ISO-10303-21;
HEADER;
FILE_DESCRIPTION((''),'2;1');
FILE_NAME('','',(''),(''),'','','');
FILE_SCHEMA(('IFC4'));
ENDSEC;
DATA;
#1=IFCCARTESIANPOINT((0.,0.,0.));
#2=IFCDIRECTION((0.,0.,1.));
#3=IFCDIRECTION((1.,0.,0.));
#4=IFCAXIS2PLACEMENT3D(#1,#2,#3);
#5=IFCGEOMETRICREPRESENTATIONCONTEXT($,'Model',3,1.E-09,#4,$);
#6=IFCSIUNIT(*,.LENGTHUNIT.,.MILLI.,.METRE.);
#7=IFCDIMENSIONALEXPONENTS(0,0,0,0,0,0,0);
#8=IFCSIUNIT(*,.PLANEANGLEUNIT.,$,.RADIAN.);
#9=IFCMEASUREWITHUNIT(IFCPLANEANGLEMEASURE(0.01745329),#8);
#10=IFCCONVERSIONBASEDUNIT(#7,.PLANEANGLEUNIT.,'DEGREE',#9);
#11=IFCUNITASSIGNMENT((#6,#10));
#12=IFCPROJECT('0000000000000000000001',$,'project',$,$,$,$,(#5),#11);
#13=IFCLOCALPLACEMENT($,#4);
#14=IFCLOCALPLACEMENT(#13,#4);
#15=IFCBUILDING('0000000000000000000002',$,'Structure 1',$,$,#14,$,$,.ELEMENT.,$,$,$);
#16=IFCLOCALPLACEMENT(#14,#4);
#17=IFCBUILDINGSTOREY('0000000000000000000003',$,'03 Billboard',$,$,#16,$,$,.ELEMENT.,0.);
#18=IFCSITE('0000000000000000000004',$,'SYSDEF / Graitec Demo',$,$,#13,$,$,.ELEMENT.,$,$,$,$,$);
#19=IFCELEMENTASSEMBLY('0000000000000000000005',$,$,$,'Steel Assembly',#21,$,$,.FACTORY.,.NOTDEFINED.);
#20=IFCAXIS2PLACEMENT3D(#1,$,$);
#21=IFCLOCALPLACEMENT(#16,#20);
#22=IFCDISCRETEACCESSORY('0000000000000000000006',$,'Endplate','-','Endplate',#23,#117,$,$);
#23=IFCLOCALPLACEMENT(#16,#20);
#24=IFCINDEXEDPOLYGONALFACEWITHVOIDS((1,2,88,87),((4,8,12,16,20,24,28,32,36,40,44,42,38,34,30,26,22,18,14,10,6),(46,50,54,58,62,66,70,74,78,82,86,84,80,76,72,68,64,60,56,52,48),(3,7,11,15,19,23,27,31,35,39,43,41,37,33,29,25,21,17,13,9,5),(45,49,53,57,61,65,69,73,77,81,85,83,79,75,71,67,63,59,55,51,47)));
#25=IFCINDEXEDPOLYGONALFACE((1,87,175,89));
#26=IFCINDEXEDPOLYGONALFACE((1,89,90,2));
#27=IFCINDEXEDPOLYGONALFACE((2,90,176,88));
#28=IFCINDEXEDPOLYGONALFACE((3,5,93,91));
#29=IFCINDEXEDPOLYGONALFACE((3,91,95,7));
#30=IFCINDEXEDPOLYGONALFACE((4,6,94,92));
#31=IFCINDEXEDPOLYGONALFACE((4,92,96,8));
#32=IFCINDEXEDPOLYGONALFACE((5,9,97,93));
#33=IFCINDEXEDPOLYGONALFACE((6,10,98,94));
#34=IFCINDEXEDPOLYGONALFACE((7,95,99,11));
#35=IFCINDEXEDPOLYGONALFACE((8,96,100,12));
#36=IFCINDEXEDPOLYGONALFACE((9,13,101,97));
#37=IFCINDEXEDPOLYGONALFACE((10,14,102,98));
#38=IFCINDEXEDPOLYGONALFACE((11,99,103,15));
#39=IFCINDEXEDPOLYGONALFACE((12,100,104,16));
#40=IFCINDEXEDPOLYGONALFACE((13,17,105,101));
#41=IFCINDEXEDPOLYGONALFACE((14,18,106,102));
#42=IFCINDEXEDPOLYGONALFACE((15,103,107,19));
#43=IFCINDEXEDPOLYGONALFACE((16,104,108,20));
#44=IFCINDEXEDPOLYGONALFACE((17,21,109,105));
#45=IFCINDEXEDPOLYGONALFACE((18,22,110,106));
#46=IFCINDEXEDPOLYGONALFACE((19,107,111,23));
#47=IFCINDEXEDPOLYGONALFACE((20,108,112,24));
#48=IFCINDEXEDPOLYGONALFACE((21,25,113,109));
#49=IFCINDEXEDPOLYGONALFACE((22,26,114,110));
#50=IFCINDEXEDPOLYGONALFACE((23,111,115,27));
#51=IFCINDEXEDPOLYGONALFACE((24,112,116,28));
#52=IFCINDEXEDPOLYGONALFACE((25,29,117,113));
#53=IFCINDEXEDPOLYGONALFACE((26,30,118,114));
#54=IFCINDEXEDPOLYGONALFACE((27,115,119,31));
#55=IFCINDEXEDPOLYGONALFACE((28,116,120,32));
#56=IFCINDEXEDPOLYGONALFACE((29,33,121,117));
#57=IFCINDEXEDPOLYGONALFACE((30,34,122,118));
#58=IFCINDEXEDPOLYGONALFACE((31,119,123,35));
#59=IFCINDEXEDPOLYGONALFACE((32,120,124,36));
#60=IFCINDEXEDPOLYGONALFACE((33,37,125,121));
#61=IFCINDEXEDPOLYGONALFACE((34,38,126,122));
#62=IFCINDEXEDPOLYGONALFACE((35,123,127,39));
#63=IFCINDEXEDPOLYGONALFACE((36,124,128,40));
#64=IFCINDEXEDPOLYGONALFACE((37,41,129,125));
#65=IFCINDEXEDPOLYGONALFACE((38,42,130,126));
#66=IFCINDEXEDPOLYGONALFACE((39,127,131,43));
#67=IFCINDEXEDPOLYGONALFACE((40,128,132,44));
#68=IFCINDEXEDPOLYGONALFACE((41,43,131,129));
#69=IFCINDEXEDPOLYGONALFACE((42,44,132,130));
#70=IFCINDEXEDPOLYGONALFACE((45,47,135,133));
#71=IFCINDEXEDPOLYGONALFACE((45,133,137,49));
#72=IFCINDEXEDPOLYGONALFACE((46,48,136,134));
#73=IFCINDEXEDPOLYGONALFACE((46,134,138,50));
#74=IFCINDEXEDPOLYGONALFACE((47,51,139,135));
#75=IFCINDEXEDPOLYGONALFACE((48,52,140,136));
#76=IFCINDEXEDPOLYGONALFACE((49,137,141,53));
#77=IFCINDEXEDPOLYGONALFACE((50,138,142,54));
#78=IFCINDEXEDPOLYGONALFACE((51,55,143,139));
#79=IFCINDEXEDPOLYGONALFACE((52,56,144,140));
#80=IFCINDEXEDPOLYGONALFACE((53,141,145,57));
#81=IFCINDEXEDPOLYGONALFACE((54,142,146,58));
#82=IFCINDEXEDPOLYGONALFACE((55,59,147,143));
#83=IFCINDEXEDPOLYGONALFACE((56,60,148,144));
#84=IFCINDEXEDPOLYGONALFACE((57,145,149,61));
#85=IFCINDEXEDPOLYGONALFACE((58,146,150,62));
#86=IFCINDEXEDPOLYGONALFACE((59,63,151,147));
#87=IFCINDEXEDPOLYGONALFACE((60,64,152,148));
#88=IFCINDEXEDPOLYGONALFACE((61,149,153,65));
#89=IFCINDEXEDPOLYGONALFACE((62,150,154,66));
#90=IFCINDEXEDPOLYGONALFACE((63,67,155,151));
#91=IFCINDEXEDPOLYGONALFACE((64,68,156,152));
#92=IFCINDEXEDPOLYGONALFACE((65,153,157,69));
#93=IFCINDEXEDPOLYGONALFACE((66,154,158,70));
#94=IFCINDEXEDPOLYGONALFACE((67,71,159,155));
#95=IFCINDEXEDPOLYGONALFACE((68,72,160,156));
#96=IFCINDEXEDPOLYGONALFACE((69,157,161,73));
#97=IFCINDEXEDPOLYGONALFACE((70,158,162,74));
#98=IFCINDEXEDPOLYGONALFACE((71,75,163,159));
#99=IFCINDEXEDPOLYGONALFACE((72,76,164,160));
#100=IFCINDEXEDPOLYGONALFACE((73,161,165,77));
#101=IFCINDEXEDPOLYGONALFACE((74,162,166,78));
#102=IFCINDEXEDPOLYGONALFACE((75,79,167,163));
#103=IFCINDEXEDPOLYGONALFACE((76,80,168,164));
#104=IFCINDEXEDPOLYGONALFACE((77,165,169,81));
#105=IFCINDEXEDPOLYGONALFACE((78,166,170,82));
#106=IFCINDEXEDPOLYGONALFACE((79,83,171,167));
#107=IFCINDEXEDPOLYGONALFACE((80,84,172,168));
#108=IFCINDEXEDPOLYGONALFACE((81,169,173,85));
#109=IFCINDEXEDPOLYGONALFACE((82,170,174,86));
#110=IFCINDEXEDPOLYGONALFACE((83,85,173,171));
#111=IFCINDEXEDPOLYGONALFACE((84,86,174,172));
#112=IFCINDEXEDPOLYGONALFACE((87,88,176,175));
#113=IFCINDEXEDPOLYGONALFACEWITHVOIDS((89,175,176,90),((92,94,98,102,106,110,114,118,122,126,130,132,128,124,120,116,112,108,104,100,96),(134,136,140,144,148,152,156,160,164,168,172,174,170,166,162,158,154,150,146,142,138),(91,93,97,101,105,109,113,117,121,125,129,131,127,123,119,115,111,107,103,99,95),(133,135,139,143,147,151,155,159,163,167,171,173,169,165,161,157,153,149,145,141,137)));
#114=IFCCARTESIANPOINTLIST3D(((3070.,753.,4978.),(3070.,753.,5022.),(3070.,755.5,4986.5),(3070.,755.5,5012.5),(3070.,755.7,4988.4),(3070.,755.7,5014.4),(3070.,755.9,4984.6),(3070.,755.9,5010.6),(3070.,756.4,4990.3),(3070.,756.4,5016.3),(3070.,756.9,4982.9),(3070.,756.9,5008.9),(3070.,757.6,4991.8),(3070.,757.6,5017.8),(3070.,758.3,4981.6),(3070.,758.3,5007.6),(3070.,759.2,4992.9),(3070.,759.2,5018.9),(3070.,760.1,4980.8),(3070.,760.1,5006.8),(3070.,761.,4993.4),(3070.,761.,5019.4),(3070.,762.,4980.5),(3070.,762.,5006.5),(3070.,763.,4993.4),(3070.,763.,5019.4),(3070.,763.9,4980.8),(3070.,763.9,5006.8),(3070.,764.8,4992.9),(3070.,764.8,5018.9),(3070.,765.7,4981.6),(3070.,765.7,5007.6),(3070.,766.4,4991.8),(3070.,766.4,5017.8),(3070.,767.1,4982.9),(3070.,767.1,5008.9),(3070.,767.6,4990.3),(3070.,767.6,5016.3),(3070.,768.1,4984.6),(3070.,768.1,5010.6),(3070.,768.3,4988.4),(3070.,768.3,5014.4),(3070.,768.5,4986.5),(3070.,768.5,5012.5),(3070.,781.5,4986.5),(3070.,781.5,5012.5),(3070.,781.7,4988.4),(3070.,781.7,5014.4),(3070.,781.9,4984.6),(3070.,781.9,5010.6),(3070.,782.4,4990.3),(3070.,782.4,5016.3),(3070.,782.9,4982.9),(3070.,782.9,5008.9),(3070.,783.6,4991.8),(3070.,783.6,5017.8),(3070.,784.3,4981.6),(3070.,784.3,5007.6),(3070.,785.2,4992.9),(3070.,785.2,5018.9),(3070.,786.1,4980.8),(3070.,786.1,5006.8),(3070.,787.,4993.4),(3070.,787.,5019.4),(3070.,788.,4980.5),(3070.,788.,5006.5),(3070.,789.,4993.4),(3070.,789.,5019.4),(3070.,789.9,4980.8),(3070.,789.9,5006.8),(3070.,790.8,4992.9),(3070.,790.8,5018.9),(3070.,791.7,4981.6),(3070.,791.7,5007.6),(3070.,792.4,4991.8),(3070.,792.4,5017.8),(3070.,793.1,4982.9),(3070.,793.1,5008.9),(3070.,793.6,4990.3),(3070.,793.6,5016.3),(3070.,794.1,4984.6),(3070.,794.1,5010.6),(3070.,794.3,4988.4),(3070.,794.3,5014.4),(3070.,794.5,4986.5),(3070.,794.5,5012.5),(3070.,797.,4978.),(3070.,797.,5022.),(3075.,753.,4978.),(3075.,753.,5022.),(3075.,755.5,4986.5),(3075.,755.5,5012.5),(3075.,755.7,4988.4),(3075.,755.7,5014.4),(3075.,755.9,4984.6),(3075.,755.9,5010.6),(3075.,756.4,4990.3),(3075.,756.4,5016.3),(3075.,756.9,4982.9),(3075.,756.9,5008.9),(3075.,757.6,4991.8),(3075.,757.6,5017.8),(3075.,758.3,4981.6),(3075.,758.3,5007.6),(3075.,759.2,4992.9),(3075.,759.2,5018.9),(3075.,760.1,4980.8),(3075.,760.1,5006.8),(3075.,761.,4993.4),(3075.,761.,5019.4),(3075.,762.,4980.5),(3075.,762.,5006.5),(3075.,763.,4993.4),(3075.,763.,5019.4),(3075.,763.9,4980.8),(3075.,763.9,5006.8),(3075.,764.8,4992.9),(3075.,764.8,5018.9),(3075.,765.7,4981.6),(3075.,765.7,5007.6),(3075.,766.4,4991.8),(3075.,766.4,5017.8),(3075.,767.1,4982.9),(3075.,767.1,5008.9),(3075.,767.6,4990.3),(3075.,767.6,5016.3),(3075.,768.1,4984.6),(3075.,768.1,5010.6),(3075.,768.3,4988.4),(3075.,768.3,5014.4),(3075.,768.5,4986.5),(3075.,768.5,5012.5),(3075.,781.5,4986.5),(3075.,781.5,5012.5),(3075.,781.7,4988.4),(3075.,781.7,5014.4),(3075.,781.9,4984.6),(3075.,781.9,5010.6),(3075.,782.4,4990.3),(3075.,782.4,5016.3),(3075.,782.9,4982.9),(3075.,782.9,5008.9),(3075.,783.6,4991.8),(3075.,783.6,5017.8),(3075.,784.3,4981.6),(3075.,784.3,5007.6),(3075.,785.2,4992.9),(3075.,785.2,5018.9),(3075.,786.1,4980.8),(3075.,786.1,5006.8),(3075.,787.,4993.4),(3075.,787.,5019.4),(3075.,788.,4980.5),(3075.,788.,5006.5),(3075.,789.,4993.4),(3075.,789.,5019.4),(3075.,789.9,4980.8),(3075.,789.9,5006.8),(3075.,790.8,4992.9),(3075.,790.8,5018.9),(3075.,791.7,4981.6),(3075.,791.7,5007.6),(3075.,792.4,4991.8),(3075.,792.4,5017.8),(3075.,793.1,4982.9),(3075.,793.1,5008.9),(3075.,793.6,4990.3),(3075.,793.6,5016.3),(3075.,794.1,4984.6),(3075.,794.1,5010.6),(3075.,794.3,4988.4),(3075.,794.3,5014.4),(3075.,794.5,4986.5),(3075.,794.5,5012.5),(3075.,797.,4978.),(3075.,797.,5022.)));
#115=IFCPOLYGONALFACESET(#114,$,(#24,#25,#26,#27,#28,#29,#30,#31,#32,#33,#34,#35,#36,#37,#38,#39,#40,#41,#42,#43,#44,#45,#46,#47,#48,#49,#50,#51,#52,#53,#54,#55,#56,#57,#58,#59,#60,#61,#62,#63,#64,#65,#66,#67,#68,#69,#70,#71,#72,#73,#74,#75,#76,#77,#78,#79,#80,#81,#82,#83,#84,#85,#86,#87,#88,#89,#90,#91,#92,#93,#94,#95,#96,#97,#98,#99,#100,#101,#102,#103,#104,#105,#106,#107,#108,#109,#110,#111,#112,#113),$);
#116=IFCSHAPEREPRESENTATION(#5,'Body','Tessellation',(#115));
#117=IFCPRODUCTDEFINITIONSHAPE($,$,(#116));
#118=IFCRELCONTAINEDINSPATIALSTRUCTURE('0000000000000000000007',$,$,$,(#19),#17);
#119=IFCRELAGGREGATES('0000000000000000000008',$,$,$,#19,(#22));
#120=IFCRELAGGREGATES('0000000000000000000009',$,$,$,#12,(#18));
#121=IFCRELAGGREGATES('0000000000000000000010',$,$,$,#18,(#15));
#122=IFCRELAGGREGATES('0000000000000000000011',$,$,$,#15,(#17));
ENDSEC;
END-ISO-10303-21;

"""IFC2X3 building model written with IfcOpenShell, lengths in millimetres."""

from ifc_helpers import new_model, entity, si_unit, converted_unit, frame, frame_2d, origin, origin_with_axes, place, context, project, spatial, polyline, circle, outline, extrude, element, aggregate, save


model = new_model("IFC2X3")

# Units and contexts
model_context = context("Model", 3, precision=1e-09, world=origin_with_axes())
ifc_project = project(units=[si_unit("LENGTHUNIT", "METRE", prefix="MILLI"), converted_unit("PLANEANGLEUNIT", "DEGREE", entity("IfcPlaneAngleMeasure", 0.01745329), si_unit("PLANEANGLEUNIT", "RADIAN"), dimensions=[0, 0, 0, 0, 0, 0, 0])], contexts=[model_context])

# Site, building, storey
site_placement = place(None, origin_with_axes())
site = spatial("IfcSite", under=ifc_project, at=site_placement, Name="SYSDEF / Graitec Demo", CompositionType="ELEMENT")
building_placement = place(site_placement, origin_with_axes())
building = spatial("IfcBuilding", under=site, at=building_placement, Name="Structure 1", CompositionType="ELEMENT")
storey_placement = place(building_placement, origin_with_axes())
storey = spatial("IfcBuildingStorey", under=building, at=storey_placement, Name="03 Billboard", CompositionType="ELEMENT", Elevation=0.0)

# Element assembly, discrete accessory, openings
assembly_1_placement = place(None, frame((-4239.1, -387.5, 4000.0), z_axis=(-1.0, 0.0, 0.0), x_axis=(0.0, 0.0, 1.0)))
assembly_1 = element("IfcElementAssembly", 1, at=assembly_1_placement, inside=storey, ObjectType="Steel Assembly", AssemblyPlace="FACTORY", PredefinedType="NOTDEFINED")
discrete_accessory_1_placement = place(assembly_1_placement, frame((1022.0, 1184.5, -7309.1), z_axis=(0.0, 0.0, -1.0), x_axis=(0.0, -1.0, 0.0)))
discrete_accessory_1 = element("IfcDiscreteAccessory", 2, at=discrete_accessory_1_placement, Name="Endplate", Description="-", ObjectType="Endplate", context=model_context, shape_type="SweptSolid", body=[
    extrude(outline(polyline([(0.0, 0.0), (44.0, 0.0), (44.0, 44.0), (0.0, 44.0), (0.0, 0.0)])), origin_with_axes(), (0.0, 0.0, 1.0), 5.0),
])
opening_1_placement = place(discrete_accessory_1_placement, frame((22.0, 22.0, 5.5), z_axis=(0.0, 0.0, -1.0), x_axis=(0.0, 1.0, 0.0)))
element("IfcOpeningElement", 3, at=opening_1_placement, cuts=discrete_accessory_1, ObjectType="Opening", context=model_context, shape_type="SweptSolid", body=[
    extrude(circle(Radius=6.5, at=frame_2d((13.0, 13.0), x_axis=(1.0, 0.0))), origin(), (0.0, 0.0, 1.0), 6.0),
])
opening_2_placement = place(discrete_accessory_1_placement, frame((22.0, 22.0, 5.5), z_axis=(0.0, 0.0, -1.0), x_axis=(0.0, 1.0, 0.0)))
element("IfcOpeningElement", 4, at=opening_2_placement, cuts=discrete_accessory_1, ObjectType="Opening", context=model_context, shape_type="SweptSolid", body=[
    extrude(circle(Radius=6.5, at=frame_2d((-13.0, 13.0), x_axis=(1.0, 0.0))), origin(), (0.0, 0.0, 1.0), 6.0),
])
opening_3_placement = place(discrete_accessory_1_placement, frame((22.0, 22.0, 5.5), z_axis=(0.0, 0.0, -1.0), x_axis=(0.0, 1.0, 0.0)))
element("IfcOpeningElement", 5, at=opening_3_placement, cuts=discrete_accessory_1, ObjectType="Opening", context=model_context, shape_type="SweptSolid", body=[
    extrude(circle(Radius=6.5, at=frame_2d((13.0, -13.0), x_axis=(1.0, 0.0))), origin(), (0.0, 0.0, 1.0), 6.0),
])
opening_4_placement = place(discrete_accessory_1_placement, frame((22.0, 22.0, 5.5), z_axis=(0.0, 0.0, -1.0), x_axis=(0.0, 1.0, 0.0)))
element("IfcOpeningElement", 6, at=opening_4_placement, cuts=discrete_accessory_1, ObjectType="Opening", context=model_context, shape_type="SweptSolid", body=[
    extrude(circle(Radius=6.5, at=frame_2d((-13.0, -13.0), x_axis=(1.0, 0.0))), origin(), (0.0, 0.0, 1.0), 6.0),
])
aggregate(assembly_1, [discrete_accessory_1])

save(model, "model.ifc")
